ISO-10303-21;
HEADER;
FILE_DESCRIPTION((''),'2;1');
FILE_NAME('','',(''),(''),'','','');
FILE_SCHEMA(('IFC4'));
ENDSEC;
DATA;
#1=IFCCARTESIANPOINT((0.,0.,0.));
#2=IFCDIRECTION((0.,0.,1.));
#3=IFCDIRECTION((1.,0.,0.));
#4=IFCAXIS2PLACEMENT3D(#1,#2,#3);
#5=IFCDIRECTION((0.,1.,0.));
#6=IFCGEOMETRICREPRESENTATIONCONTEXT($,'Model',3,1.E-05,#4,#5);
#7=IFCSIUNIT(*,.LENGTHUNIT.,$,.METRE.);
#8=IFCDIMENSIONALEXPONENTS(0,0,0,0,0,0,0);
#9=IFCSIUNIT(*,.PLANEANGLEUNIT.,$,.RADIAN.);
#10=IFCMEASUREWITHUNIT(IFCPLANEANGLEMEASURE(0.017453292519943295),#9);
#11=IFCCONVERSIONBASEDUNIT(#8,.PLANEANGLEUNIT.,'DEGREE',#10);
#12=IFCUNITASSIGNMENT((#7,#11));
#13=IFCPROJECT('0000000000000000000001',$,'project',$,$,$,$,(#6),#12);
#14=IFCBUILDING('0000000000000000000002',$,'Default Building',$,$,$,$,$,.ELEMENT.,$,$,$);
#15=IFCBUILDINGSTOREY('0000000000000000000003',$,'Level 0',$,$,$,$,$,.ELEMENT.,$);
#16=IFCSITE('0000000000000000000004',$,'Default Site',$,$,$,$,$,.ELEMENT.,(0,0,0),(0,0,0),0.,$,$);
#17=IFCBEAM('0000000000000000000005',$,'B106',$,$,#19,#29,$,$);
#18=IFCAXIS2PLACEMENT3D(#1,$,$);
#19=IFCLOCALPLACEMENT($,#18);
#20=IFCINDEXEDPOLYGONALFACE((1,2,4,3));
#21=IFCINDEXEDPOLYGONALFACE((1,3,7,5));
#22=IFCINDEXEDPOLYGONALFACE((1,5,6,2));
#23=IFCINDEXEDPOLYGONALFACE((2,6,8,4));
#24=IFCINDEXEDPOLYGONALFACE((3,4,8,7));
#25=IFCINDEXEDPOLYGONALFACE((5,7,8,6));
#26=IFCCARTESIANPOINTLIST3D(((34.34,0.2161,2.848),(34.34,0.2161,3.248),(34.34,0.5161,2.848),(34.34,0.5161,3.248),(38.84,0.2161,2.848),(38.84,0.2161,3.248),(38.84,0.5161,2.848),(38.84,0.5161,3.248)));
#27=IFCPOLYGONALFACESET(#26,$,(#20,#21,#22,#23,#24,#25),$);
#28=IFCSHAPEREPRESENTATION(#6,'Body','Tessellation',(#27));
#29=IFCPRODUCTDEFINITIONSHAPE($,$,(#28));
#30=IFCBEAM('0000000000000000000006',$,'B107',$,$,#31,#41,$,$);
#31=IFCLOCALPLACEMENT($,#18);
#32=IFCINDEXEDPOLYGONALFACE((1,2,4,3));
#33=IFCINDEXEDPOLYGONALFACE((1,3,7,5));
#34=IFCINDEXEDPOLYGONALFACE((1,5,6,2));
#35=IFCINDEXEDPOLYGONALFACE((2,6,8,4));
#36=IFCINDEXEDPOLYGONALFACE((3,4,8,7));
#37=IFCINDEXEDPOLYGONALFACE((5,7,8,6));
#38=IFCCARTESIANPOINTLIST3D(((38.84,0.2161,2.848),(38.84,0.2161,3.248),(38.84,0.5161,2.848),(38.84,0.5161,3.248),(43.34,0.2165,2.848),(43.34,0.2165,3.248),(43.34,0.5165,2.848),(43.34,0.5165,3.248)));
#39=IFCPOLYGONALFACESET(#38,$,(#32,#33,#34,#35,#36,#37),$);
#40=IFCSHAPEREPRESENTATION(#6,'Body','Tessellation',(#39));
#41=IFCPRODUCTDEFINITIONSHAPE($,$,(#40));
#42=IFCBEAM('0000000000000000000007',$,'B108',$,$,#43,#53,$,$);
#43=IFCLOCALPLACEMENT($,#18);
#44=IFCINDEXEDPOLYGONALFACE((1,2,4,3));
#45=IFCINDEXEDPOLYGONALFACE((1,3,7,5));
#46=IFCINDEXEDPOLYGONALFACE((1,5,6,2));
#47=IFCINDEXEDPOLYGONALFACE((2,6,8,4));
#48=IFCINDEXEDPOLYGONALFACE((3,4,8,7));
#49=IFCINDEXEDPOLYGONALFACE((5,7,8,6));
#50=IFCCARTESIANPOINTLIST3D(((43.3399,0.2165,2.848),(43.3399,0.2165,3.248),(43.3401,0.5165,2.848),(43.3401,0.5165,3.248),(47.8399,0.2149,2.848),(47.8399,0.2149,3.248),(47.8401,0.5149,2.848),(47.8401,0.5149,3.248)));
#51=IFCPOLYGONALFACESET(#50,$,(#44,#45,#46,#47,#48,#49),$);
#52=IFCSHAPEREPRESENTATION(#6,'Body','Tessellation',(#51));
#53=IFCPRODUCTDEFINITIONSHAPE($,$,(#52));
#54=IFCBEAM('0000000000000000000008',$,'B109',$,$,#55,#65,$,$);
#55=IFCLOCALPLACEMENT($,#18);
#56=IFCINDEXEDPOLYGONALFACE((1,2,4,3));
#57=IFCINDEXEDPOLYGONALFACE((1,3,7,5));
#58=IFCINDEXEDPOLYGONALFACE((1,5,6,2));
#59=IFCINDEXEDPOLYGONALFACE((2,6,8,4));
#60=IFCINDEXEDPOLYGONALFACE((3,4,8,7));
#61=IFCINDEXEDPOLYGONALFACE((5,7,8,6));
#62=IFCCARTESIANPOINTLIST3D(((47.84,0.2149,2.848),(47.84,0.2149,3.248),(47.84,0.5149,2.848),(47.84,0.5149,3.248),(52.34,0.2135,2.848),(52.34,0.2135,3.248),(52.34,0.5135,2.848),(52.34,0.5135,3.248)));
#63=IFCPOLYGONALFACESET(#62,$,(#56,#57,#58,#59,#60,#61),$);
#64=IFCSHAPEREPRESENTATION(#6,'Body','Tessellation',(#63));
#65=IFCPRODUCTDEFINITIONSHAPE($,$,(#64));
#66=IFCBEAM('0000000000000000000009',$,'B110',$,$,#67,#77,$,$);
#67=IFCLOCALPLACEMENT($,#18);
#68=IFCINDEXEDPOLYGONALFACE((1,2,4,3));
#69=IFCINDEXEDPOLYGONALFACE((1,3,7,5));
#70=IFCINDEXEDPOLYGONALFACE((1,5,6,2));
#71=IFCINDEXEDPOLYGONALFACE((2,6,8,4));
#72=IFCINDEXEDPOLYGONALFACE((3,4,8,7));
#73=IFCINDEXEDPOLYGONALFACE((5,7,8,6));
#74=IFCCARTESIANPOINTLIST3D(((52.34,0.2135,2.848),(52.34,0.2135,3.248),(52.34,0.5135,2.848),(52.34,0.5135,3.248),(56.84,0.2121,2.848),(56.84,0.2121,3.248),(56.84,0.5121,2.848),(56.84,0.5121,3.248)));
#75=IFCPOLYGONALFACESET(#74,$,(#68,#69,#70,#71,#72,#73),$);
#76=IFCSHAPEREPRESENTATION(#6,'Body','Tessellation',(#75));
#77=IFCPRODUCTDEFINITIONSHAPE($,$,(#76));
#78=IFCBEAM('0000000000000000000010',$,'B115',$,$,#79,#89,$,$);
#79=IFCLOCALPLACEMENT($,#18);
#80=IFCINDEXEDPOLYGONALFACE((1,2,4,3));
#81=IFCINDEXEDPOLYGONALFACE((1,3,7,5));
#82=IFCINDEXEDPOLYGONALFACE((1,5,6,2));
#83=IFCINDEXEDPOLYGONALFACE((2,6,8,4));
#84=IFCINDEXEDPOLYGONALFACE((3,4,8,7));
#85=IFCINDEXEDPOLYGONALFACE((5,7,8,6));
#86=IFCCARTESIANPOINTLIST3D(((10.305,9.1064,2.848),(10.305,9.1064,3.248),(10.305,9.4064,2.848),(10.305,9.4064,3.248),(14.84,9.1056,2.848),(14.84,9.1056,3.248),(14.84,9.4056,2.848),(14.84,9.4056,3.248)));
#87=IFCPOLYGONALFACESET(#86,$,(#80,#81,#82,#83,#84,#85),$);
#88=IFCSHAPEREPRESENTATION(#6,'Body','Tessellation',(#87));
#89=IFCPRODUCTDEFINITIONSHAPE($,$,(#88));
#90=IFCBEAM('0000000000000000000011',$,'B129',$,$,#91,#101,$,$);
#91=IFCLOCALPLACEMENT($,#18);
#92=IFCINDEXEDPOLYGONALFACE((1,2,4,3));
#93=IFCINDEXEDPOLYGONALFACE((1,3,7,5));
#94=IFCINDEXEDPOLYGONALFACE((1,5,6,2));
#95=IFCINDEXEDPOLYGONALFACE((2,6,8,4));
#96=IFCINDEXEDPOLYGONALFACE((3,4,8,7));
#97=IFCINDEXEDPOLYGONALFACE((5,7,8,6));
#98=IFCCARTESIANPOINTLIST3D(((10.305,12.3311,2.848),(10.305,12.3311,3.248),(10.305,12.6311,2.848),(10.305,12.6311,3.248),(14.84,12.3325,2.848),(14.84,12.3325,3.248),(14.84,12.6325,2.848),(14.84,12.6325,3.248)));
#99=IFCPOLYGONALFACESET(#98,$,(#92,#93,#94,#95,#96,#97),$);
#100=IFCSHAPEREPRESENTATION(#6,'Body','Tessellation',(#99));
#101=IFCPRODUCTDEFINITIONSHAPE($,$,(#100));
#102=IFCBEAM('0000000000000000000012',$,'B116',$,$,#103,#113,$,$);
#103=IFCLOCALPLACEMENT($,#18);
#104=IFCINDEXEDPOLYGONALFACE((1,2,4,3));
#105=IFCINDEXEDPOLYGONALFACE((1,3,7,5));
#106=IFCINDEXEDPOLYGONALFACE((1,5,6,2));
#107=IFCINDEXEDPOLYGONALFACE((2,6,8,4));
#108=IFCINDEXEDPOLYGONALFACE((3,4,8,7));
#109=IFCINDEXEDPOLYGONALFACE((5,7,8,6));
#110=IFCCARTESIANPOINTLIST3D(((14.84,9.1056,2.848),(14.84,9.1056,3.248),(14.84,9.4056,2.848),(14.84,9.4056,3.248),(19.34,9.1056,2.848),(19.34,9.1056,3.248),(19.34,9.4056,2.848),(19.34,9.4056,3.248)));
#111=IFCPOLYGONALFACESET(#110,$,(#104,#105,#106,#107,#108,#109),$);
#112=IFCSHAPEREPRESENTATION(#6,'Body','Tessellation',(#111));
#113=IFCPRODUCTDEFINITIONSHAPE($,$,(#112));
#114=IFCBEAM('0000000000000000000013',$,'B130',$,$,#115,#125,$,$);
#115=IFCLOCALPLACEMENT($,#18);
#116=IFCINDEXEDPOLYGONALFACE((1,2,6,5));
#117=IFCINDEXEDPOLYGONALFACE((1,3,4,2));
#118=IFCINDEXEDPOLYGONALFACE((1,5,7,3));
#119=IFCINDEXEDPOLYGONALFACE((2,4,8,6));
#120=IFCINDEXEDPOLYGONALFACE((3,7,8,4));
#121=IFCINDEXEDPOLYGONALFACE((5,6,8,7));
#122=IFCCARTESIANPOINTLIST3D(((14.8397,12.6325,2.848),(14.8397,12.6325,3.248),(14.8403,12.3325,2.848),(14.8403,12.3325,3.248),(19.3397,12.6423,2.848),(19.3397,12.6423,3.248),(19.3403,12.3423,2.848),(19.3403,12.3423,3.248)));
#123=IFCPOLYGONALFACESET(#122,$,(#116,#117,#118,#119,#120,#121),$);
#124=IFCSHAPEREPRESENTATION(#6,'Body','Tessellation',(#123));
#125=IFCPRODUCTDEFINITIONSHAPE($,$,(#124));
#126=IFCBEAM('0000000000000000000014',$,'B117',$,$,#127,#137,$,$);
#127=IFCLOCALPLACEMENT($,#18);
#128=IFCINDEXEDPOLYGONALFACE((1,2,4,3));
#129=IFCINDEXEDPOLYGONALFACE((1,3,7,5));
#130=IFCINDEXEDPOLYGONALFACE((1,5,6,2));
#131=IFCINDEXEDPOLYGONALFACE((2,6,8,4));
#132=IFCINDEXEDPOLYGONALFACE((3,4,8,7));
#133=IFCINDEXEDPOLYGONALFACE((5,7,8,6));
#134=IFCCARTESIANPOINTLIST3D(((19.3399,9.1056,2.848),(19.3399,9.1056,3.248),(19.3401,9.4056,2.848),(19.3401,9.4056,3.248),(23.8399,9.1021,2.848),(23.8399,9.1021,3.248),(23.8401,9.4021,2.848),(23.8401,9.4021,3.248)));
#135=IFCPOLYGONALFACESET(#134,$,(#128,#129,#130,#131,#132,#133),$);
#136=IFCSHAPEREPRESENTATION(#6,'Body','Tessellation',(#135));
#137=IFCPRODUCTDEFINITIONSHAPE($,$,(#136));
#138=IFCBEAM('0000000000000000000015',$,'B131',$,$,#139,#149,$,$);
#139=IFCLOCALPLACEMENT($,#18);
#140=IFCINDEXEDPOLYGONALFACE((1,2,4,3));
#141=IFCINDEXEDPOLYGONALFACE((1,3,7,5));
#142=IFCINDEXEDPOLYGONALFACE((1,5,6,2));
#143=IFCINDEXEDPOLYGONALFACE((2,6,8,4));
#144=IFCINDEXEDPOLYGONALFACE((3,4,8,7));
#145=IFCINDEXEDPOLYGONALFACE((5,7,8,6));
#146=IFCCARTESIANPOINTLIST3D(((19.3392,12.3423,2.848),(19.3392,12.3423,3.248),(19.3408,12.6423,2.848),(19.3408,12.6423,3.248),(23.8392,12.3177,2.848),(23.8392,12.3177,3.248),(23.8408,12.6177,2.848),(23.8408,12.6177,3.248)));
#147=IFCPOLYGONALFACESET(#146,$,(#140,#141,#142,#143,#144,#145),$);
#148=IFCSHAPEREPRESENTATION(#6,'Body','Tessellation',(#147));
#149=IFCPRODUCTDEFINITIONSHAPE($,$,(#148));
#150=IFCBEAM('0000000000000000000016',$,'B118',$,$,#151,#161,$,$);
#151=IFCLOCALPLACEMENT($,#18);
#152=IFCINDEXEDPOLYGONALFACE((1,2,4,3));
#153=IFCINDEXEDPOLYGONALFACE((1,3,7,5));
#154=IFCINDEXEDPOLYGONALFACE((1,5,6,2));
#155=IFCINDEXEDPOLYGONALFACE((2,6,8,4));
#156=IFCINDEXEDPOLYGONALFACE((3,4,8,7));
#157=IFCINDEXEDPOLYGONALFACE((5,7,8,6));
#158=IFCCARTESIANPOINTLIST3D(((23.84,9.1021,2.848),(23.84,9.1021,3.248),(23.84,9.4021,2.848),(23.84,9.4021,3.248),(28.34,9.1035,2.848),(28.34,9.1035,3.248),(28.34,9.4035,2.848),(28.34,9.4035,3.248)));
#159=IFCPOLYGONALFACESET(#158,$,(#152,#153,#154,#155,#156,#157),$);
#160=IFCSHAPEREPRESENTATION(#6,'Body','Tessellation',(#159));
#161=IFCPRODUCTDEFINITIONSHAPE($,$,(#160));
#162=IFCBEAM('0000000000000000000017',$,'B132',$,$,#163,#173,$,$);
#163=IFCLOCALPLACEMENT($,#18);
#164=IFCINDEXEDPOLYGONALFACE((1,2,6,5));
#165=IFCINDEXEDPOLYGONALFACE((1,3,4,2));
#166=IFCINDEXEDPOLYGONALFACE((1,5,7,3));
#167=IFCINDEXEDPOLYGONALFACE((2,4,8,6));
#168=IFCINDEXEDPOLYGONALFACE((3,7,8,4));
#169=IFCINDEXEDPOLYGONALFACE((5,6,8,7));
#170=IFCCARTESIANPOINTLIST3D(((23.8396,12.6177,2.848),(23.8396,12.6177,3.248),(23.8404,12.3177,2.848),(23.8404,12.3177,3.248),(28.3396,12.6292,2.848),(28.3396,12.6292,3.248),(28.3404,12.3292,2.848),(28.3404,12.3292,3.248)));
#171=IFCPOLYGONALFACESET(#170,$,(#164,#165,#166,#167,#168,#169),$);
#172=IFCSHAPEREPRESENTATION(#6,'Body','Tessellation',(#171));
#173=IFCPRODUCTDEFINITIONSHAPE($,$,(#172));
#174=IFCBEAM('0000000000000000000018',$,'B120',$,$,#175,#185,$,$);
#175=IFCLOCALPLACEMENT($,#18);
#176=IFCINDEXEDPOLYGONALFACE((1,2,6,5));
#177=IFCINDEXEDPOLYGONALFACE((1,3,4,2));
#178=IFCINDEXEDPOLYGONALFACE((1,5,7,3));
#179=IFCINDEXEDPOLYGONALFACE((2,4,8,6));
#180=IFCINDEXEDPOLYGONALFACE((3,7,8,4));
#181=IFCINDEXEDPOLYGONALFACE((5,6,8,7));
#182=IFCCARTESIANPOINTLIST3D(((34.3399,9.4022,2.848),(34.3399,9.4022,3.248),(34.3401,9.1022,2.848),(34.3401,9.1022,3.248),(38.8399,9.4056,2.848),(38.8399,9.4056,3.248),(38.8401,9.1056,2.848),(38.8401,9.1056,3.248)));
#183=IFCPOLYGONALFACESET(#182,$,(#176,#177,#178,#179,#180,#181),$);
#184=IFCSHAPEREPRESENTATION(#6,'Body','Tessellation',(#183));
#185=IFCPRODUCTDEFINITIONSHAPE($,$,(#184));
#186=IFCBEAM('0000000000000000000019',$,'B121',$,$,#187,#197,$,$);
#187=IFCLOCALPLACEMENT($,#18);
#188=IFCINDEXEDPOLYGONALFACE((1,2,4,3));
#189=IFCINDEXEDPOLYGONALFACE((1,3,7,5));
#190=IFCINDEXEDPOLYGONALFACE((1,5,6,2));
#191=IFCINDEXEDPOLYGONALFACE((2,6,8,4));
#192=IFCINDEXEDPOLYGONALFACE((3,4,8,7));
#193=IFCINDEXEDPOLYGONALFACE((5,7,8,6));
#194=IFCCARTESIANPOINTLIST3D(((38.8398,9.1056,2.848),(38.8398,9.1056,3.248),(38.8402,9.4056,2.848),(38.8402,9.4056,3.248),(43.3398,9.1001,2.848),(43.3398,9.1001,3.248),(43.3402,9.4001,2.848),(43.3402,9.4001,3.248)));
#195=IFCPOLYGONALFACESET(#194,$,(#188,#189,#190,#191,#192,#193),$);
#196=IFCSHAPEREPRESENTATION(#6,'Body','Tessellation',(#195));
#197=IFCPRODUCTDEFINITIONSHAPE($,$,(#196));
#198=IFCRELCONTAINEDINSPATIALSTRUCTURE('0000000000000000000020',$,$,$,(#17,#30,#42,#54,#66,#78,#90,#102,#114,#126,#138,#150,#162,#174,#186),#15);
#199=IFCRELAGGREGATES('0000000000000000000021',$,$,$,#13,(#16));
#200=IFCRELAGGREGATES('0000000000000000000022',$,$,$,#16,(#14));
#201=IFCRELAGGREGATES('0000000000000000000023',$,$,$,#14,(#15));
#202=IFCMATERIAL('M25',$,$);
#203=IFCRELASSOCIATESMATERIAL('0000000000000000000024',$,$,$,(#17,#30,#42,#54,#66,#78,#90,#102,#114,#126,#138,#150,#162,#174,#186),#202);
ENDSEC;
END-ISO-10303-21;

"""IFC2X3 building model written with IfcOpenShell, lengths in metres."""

from ifc_helpers import new_model, entity, si_unit, converted_unit, direction, frame, frame_2d, origin_with_axes, place, context, project, spatial, rectangle, extrude, material, element, save


model = new_model("IFC2X3")

# Units and contexts
model_context = context("Model", 3, precision=1e-05, world=origin_with_axes(), true_north=direction((0.0, 1.0, 0.0)))
ifc_project = project(units=[si_unit("LENGTHUNIT", "METRE"), converted_unit("PLANEANGLEUNIT", "DEGREE", entity("IfcPlaneAngleMeasure", 0.017453292519943295), si_unit("PLANEANGLEUNIT", "RADIAN"), dimensions=[0, 0, 0, 0, 0, 0, 0])], contexts=[model_context])

# Site, building, storey
site = spatial("IfcSite", under=ifc_project, Name="Default Site", CompositionType="ELEMENT", RefLatitude=(0, 0, 0), RefLongitude=(0, 0, 0), RefElevation=0.0)
building = spatial("IfcBuilding", under=site, Name="Default Building", CompositionType="ELEMENT")
storey = spatial("IfcBuildingStorey", under=building, Name="Level 0", CompositionType="ELEMENT")

# Beams
ifc_material = material(Name="M25")
placement = place(None, origin_with_axes())
element("IfcBeam", 1, at=placement, inside=storey, material=ifc_material, Name="B106", context=model_context, shape_type="SweptSolid", body=[
    extrude(rectangle(XDim=0.3, YDim=0.4, at=frame_2d((0.0, 0.0), x_axis=(0.0, 1.0, 0.0))), frame((34.34, 0.3661, 3.048), z_axis=(1.0, 0.000003, 0.0), x_axis=(0.0, 0.0, -1.0)), (0.0, 0.0, 1.0), 4.5),
])
element("IfcBeam", 2, at=placement, inside=storey, material=ifc_material, Name="B107", context=model_context, shape_type="SweptSolid", body=[
    extrude(rectangle(XDim=0.3, YDim=0.4, at=frame_2d((0.0, 0.0), x_axis=(0.0, 1.0, 0.0))), frame((38.84, 0.3661, 3.048), z_axis=(1.0, 0.000077, 0.0), x_axis=(0.0, 0.0, -1.0)), (0.0, 0.0, 1.0), 4.5),
])
element("IfcBeam", 3, at=placement, inside=storey, material=ifc_material, Name="B108", context=model_context, shape_type="SweptSolid", body=[
    extrude(rectangle(XDim=0.3, YDim=0.4, at=frame_2d((0.0, 0.0), x_axis=(0.0, 1.0, 0.0))), frame((43.34, 0.3665, 3.048), z_axis=(1.0, -0.000358, 0.0), x_axis=(0.0, 0.0, -1.0)), (0.0, 0.0, 1.0), 4.5),
])
element("IfcBeam", 4, at=placement, inside=storey, material=ifc_material, Name="B109", context=model_context, shape_type="SweptSolid", body=[
    extrude(rectangle(XDim=0.3, YDim=0.4, at=frame_2d((0.0, 0.0), x_axis=(0.0, 1.0, 0.0))), frame((47.84, 0.3649, 3.048), z_axis=(1.0, -0.000297, 0.0), x_axis=(0.0, 0.0, -1.0)), (0.0, 0.0, 1.0), 4.5),
])
element("IfcBeam", 5, at=placement, inside=storey, material=ifc_material, Name="B110", context=model_context, shape_type="SweptSolid", body=[
    extrude(rectangle(XDim=0.3, YDim=0.4, at=frame_2d((0.0, 0.0), x_axis=(0.0, 1.0, 0.0))), frame((52.34, 0.3635, 3.048), z_axis=(1.0, -0.000311, 0.0), x_axis=(0.0, 0.0, -1.0)), (0.0, 0.0, 1.0), 4.5),
])
element("IfcBeam", 6, at=placement, inside=storey, material=ifc_material, Name="B115", context=model_context, shape_type="SweptSolid", body=[
    extrude(rectangle(XDim=0.3, YDim=0.4, at=frame_2d((0.0, 0.0), x_axis=(0.0, 1.0, 0.0))), frame((10.305, 9.2564, 3.048), z_axis=(1.0, -0.000182, 0.0), x_axis=(0.0, 0.0, -1.0)), (0.0, 0.0, 1.0), 4.535),
])
element("IfcBeam", 7, at=placement, inside=storey, material=ifc_material, Name="B129", context=model_context, shape_type="SweptSolid", body=[
    extrude(rectangle(XDim=0.3, YDim=0.4, at=frame_2d((0.0, 0.0), x_axis=(0.0, 1.0, 0.0))), frame((10.305, 12.4811, 3.048), z_axis=(1.0, 0.000301, 0.0), x_axis=(0.0, 0.0, -1.0)), (0.0, 0.0, 1.0), 4.535),
])
element("IfcBeam", 8, at=placement, inside=storey, material=ifc_material, Name="B116", context=model_context, shape_type="SweptSolid", body=[
    extrude(rectangle(XDim=0.3, YDim=0.4, at=frame_2d((0.0, 0.0), x_axis=(0.0, 1.0, 0.0))), frame((14.84, 9.2556, 3.048), z_axis=(1.0, 0.000013, 0.0), x_axis=(0.0, 0.0, -1.0)), (0.0, 0.0, 1.0), 4.5),
])
element("IfcBeam", 9, at=placement, inside=storey, material=ifc_material, Name="B130", context=model_context, shape_type="SweptSolid", body=[
    extrude(rectangle(XDim=0.3, YDim=0.4, at=frame_2d((0.0, 0.0), x_axis=(0.0, 1.0, 0.0))), frame((14.84, 12.4825, 3.048), z_axis=(0.999998, 0.002176, 0.0), x_axis=(0.0, 0.0, -1.0)), (0.0, 0.0, 1.0), 4.5),
])
element("IfcBeam", 10, at=placement, inside=storey, material=ifc_material, Name="B117", context=model_context, shape_type="SweptSolid", body=[
    extrude(rectangle(XDim=0.3, YDim=0.4, at=frame_2d((0.0, 0.0), x_axis=(0.0, 1.0, 0.0))), frame((19.34, 9.2556, 3.048), z_axis=(1.0, -0.000779, 0.0), x_axis=(0.0, 0.0, -1.0)), (0.0, 0.0, 1.0), 4.5),
])
element("IfcBeam", 11, at=placement, inside=storey, material=ifc_material, Name="B131", context=model_context, shape_type="SweptSolid", body=[
    extrude(rectangle(XDim=0.3, YDim=0.4, at=frame_2d((0.0, 0.0), x_axis=(0.0, 1.0, 0.0))), frame((19.34, 12.4923, 3.048), z_axis=(0.999985, -0.005463, 0.0), x_axis=(0.0, 0.0, -1.0)), (0.0, 0.0, 1.0), 4.5001),
])
element("IfcBeam", 12, at=placement, inside=storey, material=ifc_material, Name="B118", context=model_context, shape_type="SweptSolid", body=[
    extrude(rectangle(XDim=0.3, YDim=0.4, at=frame_2d((0.0, 0.0), x_axis=(0.0, 1.0, 0.0))), frame((23.84, 9.2521, 3.048), z_axis=(1.0, 0.000307, 0.0), x_axis=(0.0, 0.0, -1.0)), (0.0, 0.0, 1.0), 4.5),
])
element("IfcBeam", 13, at=placement, inside=storey, material=ifc_material, Name="B132", context=model_context, shape_type="SweptSolid", body=[
    extrude(rectangle(XDim=0.3, YDim=0.4, at=frame_2d((0.0, 0.0), x_axis=(0.0, 1.0, 0.0))), frame((23.84, 12.4677, 3.048), z_axis=(0.999997, 0.002551, 0.0), x_axis=(0.0, 0.0, -1.0)), (0.0, 0.0, 1.0), 4.5),
])
element("IfcBeam", 14, at=placement, inside=storey, material=ifc_material, Name="B120", context=model_context, shape_type="SweptSolid", body=[
    extrude(rectangle(XDim=0.3, YDim=0.4, at=frame_2d((0.0, 0.0), x_axis=(0.0, 1.0, 0.0))), frame((34.34, 9.2522, 3.048), z_axis=(1.0, 0.000748, 0.0), x_axis=(0.0, 0.0, -1.0)), (0.0, 0.0, 1.0), 4.5),
])
element("IfcBeam", 15, at=placement, inside=storey, material=ifc_material, Name="B121", context=model_context, shape_type="SweptSolid", body=[
    extrude(rectangle(XDim=0.3, YDim=0.4, at=frame_2d((0.0, 0.0), x_axis=(0.0, 1.0, 0.0))), frame((38.84, 9.2556, 3.048), z_axis=(0.999999, -0.001227, 0.0), x_axis=(0.0, 0.0, -1.0)), (0.0, 0.0, 1.0), 4.5),
])

save(model, "model.ifc")
